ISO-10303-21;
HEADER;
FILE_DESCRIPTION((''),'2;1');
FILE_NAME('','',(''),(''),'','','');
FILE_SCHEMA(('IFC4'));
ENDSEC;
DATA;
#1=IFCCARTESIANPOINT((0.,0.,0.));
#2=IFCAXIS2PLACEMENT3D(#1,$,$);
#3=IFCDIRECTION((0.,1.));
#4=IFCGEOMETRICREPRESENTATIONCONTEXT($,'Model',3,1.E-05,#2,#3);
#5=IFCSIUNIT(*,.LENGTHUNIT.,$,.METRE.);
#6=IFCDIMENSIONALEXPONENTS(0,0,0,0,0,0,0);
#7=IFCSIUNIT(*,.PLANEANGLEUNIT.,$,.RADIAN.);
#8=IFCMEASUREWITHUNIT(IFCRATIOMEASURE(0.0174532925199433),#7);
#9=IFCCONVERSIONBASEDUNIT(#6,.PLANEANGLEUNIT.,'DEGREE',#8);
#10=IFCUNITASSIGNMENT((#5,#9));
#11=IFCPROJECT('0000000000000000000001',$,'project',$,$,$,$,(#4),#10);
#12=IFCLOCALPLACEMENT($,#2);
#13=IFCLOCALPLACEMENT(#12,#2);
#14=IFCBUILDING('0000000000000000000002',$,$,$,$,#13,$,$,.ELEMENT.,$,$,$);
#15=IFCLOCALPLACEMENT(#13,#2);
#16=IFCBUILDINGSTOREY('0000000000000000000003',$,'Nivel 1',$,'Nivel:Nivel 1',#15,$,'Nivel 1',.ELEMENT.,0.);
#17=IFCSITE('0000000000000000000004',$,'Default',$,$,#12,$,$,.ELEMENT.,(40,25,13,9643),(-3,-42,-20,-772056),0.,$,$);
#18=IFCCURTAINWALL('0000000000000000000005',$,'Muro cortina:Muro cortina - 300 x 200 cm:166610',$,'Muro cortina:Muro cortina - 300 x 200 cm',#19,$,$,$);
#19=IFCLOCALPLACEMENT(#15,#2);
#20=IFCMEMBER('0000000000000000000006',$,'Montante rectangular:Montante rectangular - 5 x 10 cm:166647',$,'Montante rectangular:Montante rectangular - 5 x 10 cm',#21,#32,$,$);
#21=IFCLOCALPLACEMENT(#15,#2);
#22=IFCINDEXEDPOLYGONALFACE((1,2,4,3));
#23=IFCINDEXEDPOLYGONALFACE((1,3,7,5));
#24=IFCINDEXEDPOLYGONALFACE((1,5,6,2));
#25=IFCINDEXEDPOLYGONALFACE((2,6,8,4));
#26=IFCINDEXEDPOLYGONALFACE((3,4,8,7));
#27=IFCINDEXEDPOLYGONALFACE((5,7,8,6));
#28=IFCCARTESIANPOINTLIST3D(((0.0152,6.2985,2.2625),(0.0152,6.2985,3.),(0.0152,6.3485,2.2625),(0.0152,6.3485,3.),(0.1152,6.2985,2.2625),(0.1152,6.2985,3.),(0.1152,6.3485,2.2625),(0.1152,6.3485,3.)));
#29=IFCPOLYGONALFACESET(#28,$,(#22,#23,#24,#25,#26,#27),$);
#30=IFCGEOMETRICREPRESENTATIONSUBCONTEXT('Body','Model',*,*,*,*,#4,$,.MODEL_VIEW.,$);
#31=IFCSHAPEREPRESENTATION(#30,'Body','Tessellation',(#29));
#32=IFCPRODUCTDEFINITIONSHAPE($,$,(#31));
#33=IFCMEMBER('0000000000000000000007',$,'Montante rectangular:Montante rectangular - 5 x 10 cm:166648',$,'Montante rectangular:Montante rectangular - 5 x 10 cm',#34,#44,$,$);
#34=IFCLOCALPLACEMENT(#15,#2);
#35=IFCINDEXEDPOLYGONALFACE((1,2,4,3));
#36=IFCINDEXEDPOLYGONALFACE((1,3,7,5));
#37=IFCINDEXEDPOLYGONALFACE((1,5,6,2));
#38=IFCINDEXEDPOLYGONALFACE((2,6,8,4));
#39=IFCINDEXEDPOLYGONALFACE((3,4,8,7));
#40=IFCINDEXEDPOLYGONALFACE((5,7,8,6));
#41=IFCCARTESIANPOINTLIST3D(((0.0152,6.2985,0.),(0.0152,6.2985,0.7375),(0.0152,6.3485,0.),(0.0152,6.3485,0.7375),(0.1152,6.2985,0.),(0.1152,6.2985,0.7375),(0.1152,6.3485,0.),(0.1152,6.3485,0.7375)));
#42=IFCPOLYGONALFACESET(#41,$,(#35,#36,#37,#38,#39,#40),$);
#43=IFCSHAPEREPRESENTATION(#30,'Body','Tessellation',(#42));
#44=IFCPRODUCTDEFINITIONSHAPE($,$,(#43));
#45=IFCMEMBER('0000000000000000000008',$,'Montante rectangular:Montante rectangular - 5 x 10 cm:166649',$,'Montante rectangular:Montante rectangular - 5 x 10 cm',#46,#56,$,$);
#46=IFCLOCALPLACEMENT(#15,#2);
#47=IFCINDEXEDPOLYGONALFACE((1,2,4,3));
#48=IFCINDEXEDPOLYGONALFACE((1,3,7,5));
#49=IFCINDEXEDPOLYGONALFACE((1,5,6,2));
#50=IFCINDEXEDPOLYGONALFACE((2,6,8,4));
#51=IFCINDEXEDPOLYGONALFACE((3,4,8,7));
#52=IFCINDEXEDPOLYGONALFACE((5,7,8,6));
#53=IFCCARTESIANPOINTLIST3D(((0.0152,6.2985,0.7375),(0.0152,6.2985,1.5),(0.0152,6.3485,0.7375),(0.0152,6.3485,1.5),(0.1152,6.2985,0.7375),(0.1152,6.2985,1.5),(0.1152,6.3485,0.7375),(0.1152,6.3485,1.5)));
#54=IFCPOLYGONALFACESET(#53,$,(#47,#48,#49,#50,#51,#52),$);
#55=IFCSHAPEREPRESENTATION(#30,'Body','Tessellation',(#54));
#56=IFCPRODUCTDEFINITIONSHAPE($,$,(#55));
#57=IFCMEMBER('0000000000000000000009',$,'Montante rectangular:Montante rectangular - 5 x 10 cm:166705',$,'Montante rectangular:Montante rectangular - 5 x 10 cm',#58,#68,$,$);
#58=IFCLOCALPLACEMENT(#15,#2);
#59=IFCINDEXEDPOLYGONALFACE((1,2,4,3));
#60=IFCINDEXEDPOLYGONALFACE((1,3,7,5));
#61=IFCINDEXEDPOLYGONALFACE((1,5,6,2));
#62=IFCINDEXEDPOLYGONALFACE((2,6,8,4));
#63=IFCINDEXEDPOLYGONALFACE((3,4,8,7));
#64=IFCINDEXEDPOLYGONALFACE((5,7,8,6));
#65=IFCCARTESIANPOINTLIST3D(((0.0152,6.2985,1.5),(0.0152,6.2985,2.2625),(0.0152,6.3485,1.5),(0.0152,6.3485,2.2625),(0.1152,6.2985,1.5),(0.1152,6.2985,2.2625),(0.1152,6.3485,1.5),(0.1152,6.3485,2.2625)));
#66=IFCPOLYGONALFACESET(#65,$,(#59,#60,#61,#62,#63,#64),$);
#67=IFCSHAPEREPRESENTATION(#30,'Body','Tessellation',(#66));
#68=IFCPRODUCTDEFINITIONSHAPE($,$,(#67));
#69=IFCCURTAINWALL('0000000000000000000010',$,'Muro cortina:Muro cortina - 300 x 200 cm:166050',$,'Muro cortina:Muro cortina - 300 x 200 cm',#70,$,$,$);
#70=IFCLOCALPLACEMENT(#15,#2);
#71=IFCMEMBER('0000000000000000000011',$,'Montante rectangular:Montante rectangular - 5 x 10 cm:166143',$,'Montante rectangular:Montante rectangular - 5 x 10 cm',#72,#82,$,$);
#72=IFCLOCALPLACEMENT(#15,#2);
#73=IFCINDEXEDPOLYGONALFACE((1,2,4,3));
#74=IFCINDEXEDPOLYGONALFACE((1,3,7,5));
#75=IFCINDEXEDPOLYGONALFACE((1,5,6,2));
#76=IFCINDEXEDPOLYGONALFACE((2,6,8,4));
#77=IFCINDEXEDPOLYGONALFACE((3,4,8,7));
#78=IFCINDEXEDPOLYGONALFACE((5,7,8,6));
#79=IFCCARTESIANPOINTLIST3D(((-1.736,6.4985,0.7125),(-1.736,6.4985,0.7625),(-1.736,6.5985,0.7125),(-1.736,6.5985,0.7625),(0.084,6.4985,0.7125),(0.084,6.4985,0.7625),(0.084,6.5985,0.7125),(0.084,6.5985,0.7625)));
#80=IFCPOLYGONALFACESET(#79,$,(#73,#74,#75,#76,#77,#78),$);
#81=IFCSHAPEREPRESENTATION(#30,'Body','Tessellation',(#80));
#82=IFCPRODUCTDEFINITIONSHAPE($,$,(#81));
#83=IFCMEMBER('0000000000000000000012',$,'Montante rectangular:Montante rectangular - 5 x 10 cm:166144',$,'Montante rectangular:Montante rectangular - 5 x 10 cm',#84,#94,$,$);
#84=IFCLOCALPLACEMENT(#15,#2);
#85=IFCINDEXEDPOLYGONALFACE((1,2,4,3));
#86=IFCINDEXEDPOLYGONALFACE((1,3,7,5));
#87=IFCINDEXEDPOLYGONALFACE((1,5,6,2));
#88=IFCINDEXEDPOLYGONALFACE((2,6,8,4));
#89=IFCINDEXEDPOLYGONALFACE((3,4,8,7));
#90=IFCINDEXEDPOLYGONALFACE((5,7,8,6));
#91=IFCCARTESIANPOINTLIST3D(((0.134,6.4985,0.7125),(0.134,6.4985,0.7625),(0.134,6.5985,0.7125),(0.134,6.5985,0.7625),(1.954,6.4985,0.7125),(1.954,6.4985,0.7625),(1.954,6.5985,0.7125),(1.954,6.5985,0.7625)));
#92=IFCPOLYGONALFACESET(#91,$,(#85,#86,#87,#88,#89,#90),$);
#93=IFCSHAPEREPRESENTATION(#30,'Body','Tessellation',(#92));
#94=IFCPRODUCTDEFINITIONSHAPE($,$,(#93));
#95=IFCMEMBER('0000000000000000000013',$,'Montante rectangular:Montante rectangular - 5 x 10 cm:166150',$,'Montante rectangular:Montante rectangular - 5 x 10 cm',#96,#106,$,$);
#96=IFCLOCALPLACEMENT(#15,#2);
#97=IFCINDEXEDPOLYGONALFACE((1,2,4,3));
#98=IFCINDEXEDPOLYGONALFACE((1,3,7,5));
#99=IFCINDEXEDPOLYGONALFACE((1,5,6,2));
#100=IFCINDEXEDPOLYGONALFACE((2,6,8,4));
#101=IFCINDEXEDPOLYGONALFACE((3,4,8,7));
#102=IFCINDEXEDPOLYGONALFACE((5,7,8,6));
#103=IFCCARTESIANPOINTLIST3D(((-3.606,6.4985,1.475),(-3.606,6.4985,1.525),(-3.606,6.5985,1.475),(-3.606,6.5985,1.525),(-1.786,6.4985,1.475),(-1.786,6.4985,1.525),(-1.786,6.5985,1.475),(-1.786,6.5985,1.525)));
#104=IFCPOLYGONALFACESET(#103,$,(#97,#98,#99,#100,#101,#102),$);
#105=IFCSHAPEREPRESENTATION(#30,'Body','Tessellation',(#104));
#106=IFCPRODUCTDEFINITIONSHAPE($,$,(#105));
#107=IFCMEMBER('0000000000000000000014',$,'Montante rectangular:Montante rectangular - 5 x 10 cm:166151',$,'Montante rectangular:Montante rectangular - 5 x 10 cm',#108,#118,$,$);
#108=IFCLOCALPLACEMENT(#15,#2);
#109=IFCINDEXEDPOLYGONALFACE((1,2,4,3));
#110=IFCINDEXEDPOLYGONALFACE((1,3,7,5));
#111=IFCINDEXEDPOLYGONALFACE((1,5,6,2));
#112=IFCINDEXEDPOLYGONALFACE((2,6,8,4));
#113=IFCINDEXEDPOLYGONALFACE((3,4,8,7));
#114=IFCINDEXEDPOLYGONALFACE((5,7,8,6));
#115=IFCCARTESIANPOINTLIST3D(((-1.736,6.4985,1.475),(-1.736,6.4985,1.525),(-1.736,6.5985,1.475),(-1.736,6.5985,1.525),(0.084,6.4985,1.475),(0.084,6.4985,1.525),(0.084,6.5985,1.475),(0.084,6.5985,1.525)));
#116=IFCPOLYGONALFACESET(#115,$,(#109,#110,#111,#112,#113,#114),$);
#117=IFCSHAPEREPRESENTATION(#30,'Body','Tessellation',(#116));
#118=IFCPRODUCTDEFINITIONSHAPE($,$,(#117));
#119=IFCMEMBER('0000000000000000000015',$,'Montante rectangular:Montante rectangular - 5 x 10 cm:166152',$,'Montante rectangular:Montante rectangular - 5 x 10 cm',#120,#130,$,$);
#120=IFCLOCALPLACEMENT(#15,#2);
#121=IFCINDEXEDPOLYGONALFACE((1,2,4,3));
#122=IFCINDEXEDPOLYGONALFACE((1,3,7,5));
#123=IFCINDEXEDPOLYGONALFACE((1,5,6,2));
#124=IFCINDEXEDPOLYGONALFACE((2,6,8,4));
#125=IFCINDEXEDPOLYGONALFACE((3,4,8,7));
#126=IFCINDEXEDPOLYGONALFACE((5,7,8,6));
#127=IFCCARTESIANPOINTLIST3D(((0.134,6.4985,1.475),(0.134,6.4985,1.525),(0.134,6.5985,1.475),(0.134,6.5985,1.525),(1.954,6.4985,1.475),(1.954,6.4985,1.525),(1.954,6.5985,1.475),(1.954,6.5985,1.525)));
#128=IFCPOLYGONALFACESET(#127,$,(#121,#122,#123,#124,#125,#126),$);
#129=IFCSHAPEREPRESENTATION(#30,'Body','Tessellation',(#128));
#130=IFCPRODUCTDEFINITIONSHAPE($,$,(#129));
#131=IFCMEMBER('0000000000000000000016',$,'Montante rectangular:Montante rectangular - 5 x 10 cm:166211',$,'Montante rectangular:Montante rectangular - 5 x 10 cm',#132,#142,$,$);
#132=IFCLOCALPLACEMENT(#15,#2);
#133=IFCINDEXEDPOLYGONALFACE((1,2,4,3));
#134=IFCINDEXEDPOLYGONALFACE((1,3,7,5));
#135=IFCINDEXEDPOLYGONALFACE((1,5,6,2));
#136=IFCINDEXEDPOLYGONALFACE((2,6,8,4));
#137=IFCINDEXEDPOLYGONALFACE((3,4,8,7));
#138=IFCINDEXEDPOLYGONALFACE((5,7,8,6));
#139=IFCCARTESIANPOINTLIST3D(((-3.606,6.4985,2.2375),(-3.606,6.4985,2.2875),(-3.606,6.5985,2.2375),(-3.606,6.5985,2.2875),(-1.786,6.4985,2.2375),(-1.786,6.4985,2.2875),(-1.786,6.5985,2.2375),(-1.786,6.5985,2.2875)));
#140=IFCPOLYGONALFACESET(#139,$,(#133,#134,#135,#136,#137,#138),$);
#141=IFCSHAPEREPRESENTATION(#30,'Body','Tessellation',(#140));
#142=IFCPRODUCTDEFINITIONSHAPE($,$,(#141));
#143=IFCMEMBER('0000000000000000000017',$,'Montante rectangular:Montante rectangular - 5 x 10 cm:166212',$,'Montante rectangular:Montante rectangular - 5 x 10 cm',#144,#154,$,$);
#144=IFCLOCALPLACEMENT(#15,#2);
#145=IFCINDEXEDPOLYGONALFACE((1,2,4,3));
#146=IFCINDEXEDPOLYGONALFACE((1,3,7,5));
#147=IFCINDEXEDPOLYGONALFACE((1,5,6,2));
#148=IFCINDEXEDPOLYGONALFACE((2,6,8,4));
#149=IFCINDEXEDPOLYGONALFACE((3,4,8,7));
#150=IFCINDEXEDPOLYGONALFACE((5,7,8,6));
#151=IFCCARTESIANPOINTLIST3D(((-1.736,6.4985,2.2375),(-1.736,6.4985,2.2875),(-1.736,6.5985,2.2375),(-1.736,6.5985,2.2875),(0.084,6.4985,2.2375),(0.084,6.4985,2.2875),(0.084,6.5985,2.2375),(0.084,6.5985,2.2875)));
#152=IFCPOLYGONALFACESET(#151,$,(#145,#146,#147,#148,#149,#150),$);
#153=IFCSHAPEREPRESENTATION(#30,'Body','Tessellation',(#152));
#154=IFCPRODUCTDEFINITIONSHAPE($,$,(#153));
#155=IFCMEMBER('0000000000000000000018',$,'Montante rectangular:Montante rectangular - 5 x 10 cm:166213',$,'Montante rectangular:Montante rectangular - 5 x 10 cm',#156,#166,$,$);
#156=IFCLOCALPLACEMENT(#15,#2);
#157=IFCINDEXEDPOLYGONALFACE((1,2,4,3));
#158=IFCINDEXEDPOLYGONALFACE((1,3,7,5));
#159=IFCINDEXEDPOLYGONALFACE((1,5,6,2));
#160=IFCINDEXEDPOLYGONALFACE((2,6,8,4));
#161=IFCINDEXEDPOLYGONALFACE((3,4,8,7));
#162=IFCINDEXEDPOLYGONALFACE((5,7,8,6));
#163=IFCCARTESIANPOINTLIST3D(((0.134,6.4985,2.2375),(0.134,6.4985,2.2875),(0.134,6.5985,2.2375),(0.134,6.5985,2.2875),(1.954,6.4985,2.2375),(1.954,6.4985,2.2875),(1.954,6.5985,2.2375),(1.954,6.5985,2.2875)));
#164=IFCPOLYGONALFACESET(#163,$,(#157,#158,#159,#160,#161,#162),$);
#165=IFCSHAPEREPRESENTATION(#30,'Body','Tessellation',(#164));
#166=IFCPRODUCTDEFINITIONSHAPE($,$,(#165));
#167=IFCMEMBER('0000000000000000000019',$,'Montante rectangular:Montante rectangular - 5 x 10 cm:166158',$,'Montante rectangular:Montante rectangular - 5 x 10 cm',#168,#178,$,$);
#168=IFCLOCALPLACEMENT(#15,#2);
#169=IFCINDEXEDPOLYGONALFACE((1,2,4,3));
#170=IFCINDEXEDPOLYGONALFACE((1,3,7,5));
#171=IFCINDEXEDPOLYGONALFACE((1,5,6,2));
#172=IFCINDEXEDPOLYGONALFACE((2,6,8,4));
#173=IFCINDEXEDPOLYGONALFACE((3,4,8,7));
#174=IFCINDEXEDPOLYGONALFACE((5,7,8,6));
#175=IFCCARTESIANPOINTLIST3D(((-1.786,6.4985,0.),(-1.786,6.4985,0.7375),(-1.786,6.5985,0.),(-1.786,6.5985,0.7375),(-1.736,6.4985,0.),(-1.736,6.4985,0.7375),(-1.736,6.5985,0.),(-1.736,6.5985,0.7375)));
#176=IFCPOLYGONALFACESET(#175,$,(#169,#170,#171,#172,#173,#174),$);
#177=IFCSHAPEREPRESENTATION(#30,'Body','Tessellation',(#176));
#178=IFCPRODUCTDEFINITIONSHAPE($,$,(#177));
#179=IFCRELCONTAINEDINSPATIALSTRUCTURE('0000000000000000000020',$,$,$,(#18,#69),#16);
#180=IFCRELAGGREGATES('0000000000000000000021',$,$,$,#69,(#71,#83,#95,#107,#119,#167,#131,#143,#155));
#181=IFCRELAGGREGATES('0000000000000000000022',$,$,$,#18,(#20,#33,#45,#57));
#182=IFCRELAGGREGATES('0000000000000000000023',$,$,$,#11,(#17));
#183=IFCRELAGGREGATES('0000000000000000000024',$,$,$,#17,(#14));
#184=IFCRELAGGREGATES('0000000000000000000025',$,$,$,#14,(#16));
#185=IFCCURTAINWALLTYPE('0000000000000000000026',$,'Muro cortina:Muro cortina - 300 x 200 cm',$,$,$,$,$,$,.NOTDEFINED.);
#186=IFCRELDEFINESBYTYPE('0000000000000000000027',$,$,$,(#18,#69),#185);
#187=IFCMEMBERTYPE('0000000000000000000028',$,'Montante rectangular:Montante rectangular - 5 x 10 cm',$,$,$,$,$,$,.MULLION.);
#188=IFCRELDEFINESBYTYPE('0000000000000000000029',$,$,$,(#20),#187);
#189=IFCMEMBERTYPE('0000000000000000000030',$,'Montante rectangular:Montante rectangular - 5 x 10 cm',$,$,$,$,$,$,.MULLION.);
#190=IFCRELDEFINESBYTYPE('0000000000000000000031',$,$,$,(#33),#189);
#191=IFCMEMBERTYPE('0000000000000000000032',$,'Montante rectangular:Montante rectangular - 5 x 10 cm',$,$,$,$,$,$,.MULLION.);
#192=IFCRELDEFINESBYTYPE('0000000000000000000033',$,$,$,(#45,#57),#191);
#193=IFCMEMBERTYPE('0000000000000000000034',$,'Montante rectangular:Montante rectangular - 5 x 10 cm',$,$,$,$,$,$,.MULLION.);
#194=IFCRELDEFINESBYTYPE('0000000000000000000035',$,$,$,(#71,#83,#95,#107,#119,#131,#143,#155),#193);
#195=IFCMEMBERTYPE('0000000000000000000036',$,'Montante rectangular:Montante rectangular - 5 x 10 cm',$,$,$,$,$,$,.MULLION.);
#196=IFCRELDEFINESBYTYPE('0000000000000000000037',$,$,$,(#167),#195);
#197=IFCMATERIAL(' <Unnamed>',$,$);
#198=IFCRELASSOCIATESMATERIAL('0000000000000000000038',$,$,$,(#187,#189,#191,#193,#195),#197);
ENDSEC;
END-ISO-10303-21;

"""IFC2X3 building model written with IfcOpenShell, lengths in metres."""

from ifc_helpers import new_model, entity, si_unit, converted_unit, direction, frame, origin, origin_2d_with_axis, place, context, subcontext, project, spatial, rectangle, extrude, source, transform, mapped, material, type_object, type_shapes, element, aggregate, save


model = new_model("IFC2X3")

# Units and contexts
model_context = context("Model", 3, precision=1e-05, world=origin(), true_north=direction((0.0, 1.0)))
body_context = subcontext(model_context, "Body", "Model", "MODEL_VIEW")
ifc_project = project(units=[si_unit("LENGTHUNIT", "METRE"), converted_unit("PLANEANGLEUNIT", "DEGREE", entity("IfcRatioMeasure", 0.0174532925199433), si_unit("PLANEANGLEUNIT", "RADIAN"), dimensions=[0, 0, 0, 0, 0, 0, 0])], contexts=[model_context])

# Site, building, storey
site_placement = place(None, origin())
site = spatial("IfcSite", under=ifc_project, at=site_placement, Name="Default", CompositionType="ELEMENT", RefLatitude=(40, 25, 13, 9643), RefLongitude=(-3, -42, -20, -772056), RefElevation=0.0)
building_placement = place(site_placement, origin())
building = spatial("IfcBuilding", under=site, at=building_placement, CompositionType="ELEMENT")
storey_placement = place(building_placement, origin())
storey = spatial("IfcBuildingStorey", under=building, at=storey_placement, Name="Nivel 1", ObjectType="Nivel:Nivel 1", LongName="Nivel 1", CompositionType="ELEMENT", Elevation=0.0)

# Curtain wall, members
curtain_wall_type = type_object("IfcCurtainWallType", Name="Muro cortina:Muro cortina - 300 x 200 cm", PredefinedType="NOTDEFINED")
curtain_wall_1_placement = place(storey_placement, origin())
curtain_wall_1 = element("IfcCurtainWall", 1, at=curtain_wall_1_placement, inside=storey, type_object=curtain_wall_type, Name="Muro cortina:Muro cortina - 300 x 200 cm:166610", ObjectType="Muro cortina:Muro cortina - 300 x 200 cm")
ifc_material_1 = material(Name=" <Unnamed>")
member_type_1 = type_object("IfcMemberType", Name="Montante rectangular:Montante rectangular - 5 x 10 cm", PredefinedType="MULLION", material=ifc_material_1)
shared_shape_1 = source(origin(), body_context, "Body", "SweptSolid", [
    extrude(rectangle(XDim=0.1, YDim=0.05, at=origin_2d_with_axis()), frame((-0.025, 0.0, -0.7375), z_axis=(0.0, 0.0, 1.0), x_axis=(0.0, -1.0, 0.0)), (0.0, 0.0, 1.0), 0.7375),
])
type_shapes(member_type_1, [shared_shape_1])
member_1_placement = place(storey_placement, frame((0.0652, 6.3485, 3.0), z_axis=(0.0, 0.0, 1.0), x_axis=(0.0, 1.0, 0.0)))
member_1 = element("IfcMember", 2, at=member_1_placement, type_object=member_type_1, Name="Montante rectangular:Montante rectangular - 5 x 10 cm:166647", ObjectType="Montante rectangular:Montante rectangular - 5 x 10 cm", context=body_context, shape_type="MappedRepresentation", body=[
    mapped(shared_shape_1, transform((0.0, 0.0, 0.0), scale=1.0)),
])
member_type_2 = type_object("IfcMemberType", Name="Montante rectangular:Montante rectangular - 5 x 10 cm", PredefinedType="MULLION", material=ifc_material_1)
shared_shape_2 = source(origin(), body_context, "Body", "SweptSolid", [
    extrude(rectangle(XDim=0.1, YDim=0.05, at=origin_2d_with_axis()), frame((-0.025, 0.0, -0.7375), z_axis=(0.0, 0.0, 1.0), x_axis=(0.0, -1.0, 0.0)), (0.0, 0.0, 1.0), 0.7375),
])
type_shapes(member_type_2, [shared_shape_2])
member_2_placement = place(storey_placement, frame((0.0652, 6.3485, 0.7375), z_axis=(0.0, 0.0, 1.0), x_axis=(0.0, 1.0, 0.0)))
member_2 = element("IfcMember", 3, at=member_2_placement, type_object=member_type_2, Name="Montante rectangular:Montante rectangular - 5 x 10 cm:166648", ObjectType="Montante rectangular:Montante rectangular - 5 x 10 cm", context=body_context, shape_type="MappedRepresentation", body=[
    mapped(shared_shape_2, transform((0.0, 0.0, 0.0), scale=1.0)),
])
member_type_3 = type_object("IfcMemberType", Name="Montante rectangular:Montante rectangular - 5 x 10 cm", PredefinedType="MULLION", material=ifc_material_1)
shared_shape_3 = source(origin(), body_context, "Body", "SweptSolid", [
    extrude(rectangle(XDim=0.1, YDim=0.05, at=origin_2d_with_axis()), frame((-0.025, 0.0, -0.7625), z_axis=(0.0, 0.0, 1.0), x_axis=(0.0, -1.0, 0.0)), (0.0, 0.0, 1.0), 0.7625),
])
type_shapes(member_type_3, [shared_shape_3])
member_3_placement = place(storey_placement, frame((0.0652, 6.3485, 1.5), z_axis=(0.0, 0.0, 1.0), x_axis=(0.0, 1.0, 0.0)))
member_3 = element("IfcMember", 4, at=member_3_placement, type_object=member_type_3, Name="Montante rectangular:Montante rectangular - 5 x 10 cm:166649", ObjectType="Montante rectangular:Montante rectangular - 5 x 10 cm", context=body_context, shape_type="MappedRepresentation", body=[
    mapped(shared_shape_3, transform((0.0, 0.0, 0.0), scale=1.0)),
])
member_4_placement = place(storey_placement, frame((0.0652, 6.3485, 2.2625), z_axis=(0.0, 0.0, 1.0), x_axis=(0.0, 1.0, 0.0)))
member_4 = element("IfcMember", 5, at=member_4_placement, type_object=member_type_3, Name="Montante rectangular:Montante rectangular - 5 x 10 cm:166705", ObjectType="Montante rectangular:Montante rectangular - 5 x 10 cm", context=body_context, shape_type="MappedRepresentation", body=[
    mapped(shared_shape_3, transform((0.0, 0.0, 0.0), scale=1.0)),
])

# Curtain wall, members
curtain_wall_2_placement = place(storey_placement, origin())
curtain_wall_2 = element("IfcCurtainWall", 6, at=curtain_wall_2_placement, inside=storey, type_object=curtain_wall_type, Name="Muro cortina:Muro cortina - 300 x 200 cm:166050", ObjectType="Muro cortina:Muro cortina - 300 x 200 cm")
member_type_4 = type_object("IfcMemberType", Name="Montante rectangular:Montante rectangular - 5 x 10 cm", PredefinedType="MULLION", material=ifc_material_1)
shared_shape_4 = source(origin(), body_context, "Body", "SweptSolid", [
    extrude(rectangle(XDim=0.1, YDim=0.05, at=origin_2d_with_axis()), frame((0.0, 0.0, -1.82), z_axis=(0.0, 0.0, 1.0), x_axis=(0.0, -1.0, 0.0)), (0.0, 0.0, 1.0), 1.82),
])
type_shapes(member_type_4, [shared_shape_4])
member_5_placement = place(storey_placement, frame((0.084, 6.5485, 0.7375), z_axis=(1.0, 0.0, 0.0), x_axis=(0.0, 0.0, 1.0)))
member_5 = element("IfcMember", 7, at=member_5_placement, type_object=member_type_4, Name="Montante rectangular:Montante rectangular - 5 x 10 cm:166143", ObjectType="Montante rectangular:Montante rectangular - 5 x 10 cm", context=body_context, shape_type="MappedRepresentation", body=[
    mapped(shared_shape_4, transform((0.0, 0.0, 0.0), scale=1.0)),
])
member_6_placement = place(storey_placement, frame((1.954, 6.5485, 0.7375), z_axis=(1.0, 0.0, 0.0), x_axis=(0.0, 0.0, 1.0)))
member_6 = element("IfcMember", 8, at=member_6_placement, type_object=member_type_4, Name="Montante rectangular:Montante rectangular - 5 x 10 cm:166144", ObjectType="Montante rectangular:Montante rectangular - 5 x 10 cm", context=body_context, shape_type="MappedRepresentation", body=[
    mapped(shared_shape_4, transform((0.0, 0.0, 0.0), scale=1.0)),
])
member_7_placement = place(storey_placement, frame((-1.786, 6.5485, 1.5), z_axis=(1.0, 0.0, 0.0), x_axis=(0.0, 0.0, 1.0)))
member_7 = element("IfcMember", 9, at=member_7_placement, type_object=member_type_4, Name="Montante rectangular:Montante rectangular - 5 x 10 cm:166150", ObjectType="Montante rectangular:Montante rectangular - 5 x 10 cm", context=body_context, shape_type="MappedRepresentation", body=[
    mapped(shared_shape_4, transform((0.0, 0.0, 0.0), scale=1.0)),
])
member_8_placement = place(storey_placement, frame((0.084, 6.5485, 1.5), z_axis=(1.0, 0.0, 0.0), x_axis=(0.0, 0.0, 1.0)))
member_8 = element("IfcMember", 10, at=member_8_placement, type_object=member_type_4, Name="Montante rectangular:Montante rectangular - 5 x 10 cm:166151", ObjectType="Montante rectangular:Montante rectangular - 5 x 10 cm", context=body_context, shape_type="MappedRepresentation", body=[
    mapped(shared_shape_4, transform((0.0, 0.0, 0.0), scale=1.0)),
])
member_9_placement = place(storey_placement, frame((1.954, 6.5485, 1.5), z_axis=(1.0, 0.0, 0.0), x_axis=(0.0, 0.0, 1.0)))
member_9 = element("IfcMember", 11, at=member_9_placement, type_object=member_type_4, Name="Montante rectangular:Montante rectangular - 5 x 10 cm:166152", ObjectType="Montante rectangular:Montante rectangular - 5 x 10 cm", context=body_context, shape_type="MappedRepresentation", body=[
    mapped(shared_shape_4, transform((0.0, 0.0, 0.0), scale=1.0)),
])
member_10_placement = place(storey_placement, frame((-1.786, 6.5485, 2.2625), z_axis=(1.0, 0.0, 0.0), x_axis=(0.0, 0.0, 1.0)))
member_10 = element("IfcMember", 12, at=member_10_placement, type_object=member_type_4, Name="Montante rectangular:Montante rectangular - 5 x 10 cm:166211", ObjectType="Montante rectangular:Montante rectangular - 5 x 10 cm", context=body_context, shape_type="MappedRepresentation", body=[
    mapped(shared_shape_4, transform((0.0, 0.0, 0.0), scale=1.0)),
])
member_11_placement = place(storey_placement, frame((0.084, 6.5485, 2.2625), z_axis=(1.0, 0.0, 0.0), x_axis=(0.0, 0.0, 1.0)))
member_11 = element("IfcMember", 13, at=member_11_placement, type_object=member_type_4, Name="Montante rectangular:Montante rectangular - 5 x 10 cm:166212", ObjectType="Montante rectangular:Montante rectangular - 5 x 10 cm", context=body_context, shape_type="MappedRepresentation", body=[
    mapped(shared_shape_4, transform((0.0, 0.0, 0.0), scale=1.0)),
])
member_12_placement = place(storey_placement, frame((1.954, 6.5485, 2.2625), z_axis=(1.0, 0.0, 0.0), x_axis=(0.0, 0.0, 1.0)))
member_12 = element("IfcMember", 14, at=member_12_placement, type_object=member_type_4, Name="Montante rectangular:Montante rectangular - 5 x 10 cm:166213", ObjectType="Montante rectangular:Montante rectangular - 5 x 10 cm", context=body_context, shape_type="MappedRepresentation", body=[
    mapped(shared_shape_4, transform((0.0, 0.0, 0.0), scale=1.0)),
])
member_type_5 = type_object("IfcMemberType", Name="Montante rectangular:Montante rectangular - 5 x 10 cm", PredefinedType="MULLION", material=ifc_material_1)
shared_shape_5 = source(origin(), body_context, "Body", "SweptSolid", [
    extrude(rectangle(XDim=0.1, YDim=0.05, at=origin_2d_with_axis()), frame((0.0, 0.0, -0.7375), z_axis=(0.0, 0.0, 1.0), x_axis=(0.0, -1.0, 0.0)), (0.0, 0.0, 1.0), 0.7375),
])
type_shapes(member_type_5, [shared_shape_5])
member_13_placement = place(storey_placement, frame((-1.761, 6.5485, 0.0), z_axis=(0.0, 0.0, -1.0), x_axis=(1.0, 0.0, 0.0)))
member_13 = element("IfcMember", 15, at=member_13_placement, type_object=member_type_5, Name="Montante rectangular:Montante rectangular - 5 x 10 cm:166158", ObjectType="Montante rectangular:Montante rectangular - 5 x 10 cm", context=body_context, shape_type="MappedRepresentation", body=[
    mapped(shared_shape_5, transform((0.0, 0.0, 0.0), scale=1.0)),
])
aggregate(curtain_wall_2, [member_5, member_6, member_7, member_8, member_9, member_13, member_10, member_11, member_12])

aggregate(curtain_wall_1, [member_1, member_2, member_3, member_4])

save(model, "model.ifc")
